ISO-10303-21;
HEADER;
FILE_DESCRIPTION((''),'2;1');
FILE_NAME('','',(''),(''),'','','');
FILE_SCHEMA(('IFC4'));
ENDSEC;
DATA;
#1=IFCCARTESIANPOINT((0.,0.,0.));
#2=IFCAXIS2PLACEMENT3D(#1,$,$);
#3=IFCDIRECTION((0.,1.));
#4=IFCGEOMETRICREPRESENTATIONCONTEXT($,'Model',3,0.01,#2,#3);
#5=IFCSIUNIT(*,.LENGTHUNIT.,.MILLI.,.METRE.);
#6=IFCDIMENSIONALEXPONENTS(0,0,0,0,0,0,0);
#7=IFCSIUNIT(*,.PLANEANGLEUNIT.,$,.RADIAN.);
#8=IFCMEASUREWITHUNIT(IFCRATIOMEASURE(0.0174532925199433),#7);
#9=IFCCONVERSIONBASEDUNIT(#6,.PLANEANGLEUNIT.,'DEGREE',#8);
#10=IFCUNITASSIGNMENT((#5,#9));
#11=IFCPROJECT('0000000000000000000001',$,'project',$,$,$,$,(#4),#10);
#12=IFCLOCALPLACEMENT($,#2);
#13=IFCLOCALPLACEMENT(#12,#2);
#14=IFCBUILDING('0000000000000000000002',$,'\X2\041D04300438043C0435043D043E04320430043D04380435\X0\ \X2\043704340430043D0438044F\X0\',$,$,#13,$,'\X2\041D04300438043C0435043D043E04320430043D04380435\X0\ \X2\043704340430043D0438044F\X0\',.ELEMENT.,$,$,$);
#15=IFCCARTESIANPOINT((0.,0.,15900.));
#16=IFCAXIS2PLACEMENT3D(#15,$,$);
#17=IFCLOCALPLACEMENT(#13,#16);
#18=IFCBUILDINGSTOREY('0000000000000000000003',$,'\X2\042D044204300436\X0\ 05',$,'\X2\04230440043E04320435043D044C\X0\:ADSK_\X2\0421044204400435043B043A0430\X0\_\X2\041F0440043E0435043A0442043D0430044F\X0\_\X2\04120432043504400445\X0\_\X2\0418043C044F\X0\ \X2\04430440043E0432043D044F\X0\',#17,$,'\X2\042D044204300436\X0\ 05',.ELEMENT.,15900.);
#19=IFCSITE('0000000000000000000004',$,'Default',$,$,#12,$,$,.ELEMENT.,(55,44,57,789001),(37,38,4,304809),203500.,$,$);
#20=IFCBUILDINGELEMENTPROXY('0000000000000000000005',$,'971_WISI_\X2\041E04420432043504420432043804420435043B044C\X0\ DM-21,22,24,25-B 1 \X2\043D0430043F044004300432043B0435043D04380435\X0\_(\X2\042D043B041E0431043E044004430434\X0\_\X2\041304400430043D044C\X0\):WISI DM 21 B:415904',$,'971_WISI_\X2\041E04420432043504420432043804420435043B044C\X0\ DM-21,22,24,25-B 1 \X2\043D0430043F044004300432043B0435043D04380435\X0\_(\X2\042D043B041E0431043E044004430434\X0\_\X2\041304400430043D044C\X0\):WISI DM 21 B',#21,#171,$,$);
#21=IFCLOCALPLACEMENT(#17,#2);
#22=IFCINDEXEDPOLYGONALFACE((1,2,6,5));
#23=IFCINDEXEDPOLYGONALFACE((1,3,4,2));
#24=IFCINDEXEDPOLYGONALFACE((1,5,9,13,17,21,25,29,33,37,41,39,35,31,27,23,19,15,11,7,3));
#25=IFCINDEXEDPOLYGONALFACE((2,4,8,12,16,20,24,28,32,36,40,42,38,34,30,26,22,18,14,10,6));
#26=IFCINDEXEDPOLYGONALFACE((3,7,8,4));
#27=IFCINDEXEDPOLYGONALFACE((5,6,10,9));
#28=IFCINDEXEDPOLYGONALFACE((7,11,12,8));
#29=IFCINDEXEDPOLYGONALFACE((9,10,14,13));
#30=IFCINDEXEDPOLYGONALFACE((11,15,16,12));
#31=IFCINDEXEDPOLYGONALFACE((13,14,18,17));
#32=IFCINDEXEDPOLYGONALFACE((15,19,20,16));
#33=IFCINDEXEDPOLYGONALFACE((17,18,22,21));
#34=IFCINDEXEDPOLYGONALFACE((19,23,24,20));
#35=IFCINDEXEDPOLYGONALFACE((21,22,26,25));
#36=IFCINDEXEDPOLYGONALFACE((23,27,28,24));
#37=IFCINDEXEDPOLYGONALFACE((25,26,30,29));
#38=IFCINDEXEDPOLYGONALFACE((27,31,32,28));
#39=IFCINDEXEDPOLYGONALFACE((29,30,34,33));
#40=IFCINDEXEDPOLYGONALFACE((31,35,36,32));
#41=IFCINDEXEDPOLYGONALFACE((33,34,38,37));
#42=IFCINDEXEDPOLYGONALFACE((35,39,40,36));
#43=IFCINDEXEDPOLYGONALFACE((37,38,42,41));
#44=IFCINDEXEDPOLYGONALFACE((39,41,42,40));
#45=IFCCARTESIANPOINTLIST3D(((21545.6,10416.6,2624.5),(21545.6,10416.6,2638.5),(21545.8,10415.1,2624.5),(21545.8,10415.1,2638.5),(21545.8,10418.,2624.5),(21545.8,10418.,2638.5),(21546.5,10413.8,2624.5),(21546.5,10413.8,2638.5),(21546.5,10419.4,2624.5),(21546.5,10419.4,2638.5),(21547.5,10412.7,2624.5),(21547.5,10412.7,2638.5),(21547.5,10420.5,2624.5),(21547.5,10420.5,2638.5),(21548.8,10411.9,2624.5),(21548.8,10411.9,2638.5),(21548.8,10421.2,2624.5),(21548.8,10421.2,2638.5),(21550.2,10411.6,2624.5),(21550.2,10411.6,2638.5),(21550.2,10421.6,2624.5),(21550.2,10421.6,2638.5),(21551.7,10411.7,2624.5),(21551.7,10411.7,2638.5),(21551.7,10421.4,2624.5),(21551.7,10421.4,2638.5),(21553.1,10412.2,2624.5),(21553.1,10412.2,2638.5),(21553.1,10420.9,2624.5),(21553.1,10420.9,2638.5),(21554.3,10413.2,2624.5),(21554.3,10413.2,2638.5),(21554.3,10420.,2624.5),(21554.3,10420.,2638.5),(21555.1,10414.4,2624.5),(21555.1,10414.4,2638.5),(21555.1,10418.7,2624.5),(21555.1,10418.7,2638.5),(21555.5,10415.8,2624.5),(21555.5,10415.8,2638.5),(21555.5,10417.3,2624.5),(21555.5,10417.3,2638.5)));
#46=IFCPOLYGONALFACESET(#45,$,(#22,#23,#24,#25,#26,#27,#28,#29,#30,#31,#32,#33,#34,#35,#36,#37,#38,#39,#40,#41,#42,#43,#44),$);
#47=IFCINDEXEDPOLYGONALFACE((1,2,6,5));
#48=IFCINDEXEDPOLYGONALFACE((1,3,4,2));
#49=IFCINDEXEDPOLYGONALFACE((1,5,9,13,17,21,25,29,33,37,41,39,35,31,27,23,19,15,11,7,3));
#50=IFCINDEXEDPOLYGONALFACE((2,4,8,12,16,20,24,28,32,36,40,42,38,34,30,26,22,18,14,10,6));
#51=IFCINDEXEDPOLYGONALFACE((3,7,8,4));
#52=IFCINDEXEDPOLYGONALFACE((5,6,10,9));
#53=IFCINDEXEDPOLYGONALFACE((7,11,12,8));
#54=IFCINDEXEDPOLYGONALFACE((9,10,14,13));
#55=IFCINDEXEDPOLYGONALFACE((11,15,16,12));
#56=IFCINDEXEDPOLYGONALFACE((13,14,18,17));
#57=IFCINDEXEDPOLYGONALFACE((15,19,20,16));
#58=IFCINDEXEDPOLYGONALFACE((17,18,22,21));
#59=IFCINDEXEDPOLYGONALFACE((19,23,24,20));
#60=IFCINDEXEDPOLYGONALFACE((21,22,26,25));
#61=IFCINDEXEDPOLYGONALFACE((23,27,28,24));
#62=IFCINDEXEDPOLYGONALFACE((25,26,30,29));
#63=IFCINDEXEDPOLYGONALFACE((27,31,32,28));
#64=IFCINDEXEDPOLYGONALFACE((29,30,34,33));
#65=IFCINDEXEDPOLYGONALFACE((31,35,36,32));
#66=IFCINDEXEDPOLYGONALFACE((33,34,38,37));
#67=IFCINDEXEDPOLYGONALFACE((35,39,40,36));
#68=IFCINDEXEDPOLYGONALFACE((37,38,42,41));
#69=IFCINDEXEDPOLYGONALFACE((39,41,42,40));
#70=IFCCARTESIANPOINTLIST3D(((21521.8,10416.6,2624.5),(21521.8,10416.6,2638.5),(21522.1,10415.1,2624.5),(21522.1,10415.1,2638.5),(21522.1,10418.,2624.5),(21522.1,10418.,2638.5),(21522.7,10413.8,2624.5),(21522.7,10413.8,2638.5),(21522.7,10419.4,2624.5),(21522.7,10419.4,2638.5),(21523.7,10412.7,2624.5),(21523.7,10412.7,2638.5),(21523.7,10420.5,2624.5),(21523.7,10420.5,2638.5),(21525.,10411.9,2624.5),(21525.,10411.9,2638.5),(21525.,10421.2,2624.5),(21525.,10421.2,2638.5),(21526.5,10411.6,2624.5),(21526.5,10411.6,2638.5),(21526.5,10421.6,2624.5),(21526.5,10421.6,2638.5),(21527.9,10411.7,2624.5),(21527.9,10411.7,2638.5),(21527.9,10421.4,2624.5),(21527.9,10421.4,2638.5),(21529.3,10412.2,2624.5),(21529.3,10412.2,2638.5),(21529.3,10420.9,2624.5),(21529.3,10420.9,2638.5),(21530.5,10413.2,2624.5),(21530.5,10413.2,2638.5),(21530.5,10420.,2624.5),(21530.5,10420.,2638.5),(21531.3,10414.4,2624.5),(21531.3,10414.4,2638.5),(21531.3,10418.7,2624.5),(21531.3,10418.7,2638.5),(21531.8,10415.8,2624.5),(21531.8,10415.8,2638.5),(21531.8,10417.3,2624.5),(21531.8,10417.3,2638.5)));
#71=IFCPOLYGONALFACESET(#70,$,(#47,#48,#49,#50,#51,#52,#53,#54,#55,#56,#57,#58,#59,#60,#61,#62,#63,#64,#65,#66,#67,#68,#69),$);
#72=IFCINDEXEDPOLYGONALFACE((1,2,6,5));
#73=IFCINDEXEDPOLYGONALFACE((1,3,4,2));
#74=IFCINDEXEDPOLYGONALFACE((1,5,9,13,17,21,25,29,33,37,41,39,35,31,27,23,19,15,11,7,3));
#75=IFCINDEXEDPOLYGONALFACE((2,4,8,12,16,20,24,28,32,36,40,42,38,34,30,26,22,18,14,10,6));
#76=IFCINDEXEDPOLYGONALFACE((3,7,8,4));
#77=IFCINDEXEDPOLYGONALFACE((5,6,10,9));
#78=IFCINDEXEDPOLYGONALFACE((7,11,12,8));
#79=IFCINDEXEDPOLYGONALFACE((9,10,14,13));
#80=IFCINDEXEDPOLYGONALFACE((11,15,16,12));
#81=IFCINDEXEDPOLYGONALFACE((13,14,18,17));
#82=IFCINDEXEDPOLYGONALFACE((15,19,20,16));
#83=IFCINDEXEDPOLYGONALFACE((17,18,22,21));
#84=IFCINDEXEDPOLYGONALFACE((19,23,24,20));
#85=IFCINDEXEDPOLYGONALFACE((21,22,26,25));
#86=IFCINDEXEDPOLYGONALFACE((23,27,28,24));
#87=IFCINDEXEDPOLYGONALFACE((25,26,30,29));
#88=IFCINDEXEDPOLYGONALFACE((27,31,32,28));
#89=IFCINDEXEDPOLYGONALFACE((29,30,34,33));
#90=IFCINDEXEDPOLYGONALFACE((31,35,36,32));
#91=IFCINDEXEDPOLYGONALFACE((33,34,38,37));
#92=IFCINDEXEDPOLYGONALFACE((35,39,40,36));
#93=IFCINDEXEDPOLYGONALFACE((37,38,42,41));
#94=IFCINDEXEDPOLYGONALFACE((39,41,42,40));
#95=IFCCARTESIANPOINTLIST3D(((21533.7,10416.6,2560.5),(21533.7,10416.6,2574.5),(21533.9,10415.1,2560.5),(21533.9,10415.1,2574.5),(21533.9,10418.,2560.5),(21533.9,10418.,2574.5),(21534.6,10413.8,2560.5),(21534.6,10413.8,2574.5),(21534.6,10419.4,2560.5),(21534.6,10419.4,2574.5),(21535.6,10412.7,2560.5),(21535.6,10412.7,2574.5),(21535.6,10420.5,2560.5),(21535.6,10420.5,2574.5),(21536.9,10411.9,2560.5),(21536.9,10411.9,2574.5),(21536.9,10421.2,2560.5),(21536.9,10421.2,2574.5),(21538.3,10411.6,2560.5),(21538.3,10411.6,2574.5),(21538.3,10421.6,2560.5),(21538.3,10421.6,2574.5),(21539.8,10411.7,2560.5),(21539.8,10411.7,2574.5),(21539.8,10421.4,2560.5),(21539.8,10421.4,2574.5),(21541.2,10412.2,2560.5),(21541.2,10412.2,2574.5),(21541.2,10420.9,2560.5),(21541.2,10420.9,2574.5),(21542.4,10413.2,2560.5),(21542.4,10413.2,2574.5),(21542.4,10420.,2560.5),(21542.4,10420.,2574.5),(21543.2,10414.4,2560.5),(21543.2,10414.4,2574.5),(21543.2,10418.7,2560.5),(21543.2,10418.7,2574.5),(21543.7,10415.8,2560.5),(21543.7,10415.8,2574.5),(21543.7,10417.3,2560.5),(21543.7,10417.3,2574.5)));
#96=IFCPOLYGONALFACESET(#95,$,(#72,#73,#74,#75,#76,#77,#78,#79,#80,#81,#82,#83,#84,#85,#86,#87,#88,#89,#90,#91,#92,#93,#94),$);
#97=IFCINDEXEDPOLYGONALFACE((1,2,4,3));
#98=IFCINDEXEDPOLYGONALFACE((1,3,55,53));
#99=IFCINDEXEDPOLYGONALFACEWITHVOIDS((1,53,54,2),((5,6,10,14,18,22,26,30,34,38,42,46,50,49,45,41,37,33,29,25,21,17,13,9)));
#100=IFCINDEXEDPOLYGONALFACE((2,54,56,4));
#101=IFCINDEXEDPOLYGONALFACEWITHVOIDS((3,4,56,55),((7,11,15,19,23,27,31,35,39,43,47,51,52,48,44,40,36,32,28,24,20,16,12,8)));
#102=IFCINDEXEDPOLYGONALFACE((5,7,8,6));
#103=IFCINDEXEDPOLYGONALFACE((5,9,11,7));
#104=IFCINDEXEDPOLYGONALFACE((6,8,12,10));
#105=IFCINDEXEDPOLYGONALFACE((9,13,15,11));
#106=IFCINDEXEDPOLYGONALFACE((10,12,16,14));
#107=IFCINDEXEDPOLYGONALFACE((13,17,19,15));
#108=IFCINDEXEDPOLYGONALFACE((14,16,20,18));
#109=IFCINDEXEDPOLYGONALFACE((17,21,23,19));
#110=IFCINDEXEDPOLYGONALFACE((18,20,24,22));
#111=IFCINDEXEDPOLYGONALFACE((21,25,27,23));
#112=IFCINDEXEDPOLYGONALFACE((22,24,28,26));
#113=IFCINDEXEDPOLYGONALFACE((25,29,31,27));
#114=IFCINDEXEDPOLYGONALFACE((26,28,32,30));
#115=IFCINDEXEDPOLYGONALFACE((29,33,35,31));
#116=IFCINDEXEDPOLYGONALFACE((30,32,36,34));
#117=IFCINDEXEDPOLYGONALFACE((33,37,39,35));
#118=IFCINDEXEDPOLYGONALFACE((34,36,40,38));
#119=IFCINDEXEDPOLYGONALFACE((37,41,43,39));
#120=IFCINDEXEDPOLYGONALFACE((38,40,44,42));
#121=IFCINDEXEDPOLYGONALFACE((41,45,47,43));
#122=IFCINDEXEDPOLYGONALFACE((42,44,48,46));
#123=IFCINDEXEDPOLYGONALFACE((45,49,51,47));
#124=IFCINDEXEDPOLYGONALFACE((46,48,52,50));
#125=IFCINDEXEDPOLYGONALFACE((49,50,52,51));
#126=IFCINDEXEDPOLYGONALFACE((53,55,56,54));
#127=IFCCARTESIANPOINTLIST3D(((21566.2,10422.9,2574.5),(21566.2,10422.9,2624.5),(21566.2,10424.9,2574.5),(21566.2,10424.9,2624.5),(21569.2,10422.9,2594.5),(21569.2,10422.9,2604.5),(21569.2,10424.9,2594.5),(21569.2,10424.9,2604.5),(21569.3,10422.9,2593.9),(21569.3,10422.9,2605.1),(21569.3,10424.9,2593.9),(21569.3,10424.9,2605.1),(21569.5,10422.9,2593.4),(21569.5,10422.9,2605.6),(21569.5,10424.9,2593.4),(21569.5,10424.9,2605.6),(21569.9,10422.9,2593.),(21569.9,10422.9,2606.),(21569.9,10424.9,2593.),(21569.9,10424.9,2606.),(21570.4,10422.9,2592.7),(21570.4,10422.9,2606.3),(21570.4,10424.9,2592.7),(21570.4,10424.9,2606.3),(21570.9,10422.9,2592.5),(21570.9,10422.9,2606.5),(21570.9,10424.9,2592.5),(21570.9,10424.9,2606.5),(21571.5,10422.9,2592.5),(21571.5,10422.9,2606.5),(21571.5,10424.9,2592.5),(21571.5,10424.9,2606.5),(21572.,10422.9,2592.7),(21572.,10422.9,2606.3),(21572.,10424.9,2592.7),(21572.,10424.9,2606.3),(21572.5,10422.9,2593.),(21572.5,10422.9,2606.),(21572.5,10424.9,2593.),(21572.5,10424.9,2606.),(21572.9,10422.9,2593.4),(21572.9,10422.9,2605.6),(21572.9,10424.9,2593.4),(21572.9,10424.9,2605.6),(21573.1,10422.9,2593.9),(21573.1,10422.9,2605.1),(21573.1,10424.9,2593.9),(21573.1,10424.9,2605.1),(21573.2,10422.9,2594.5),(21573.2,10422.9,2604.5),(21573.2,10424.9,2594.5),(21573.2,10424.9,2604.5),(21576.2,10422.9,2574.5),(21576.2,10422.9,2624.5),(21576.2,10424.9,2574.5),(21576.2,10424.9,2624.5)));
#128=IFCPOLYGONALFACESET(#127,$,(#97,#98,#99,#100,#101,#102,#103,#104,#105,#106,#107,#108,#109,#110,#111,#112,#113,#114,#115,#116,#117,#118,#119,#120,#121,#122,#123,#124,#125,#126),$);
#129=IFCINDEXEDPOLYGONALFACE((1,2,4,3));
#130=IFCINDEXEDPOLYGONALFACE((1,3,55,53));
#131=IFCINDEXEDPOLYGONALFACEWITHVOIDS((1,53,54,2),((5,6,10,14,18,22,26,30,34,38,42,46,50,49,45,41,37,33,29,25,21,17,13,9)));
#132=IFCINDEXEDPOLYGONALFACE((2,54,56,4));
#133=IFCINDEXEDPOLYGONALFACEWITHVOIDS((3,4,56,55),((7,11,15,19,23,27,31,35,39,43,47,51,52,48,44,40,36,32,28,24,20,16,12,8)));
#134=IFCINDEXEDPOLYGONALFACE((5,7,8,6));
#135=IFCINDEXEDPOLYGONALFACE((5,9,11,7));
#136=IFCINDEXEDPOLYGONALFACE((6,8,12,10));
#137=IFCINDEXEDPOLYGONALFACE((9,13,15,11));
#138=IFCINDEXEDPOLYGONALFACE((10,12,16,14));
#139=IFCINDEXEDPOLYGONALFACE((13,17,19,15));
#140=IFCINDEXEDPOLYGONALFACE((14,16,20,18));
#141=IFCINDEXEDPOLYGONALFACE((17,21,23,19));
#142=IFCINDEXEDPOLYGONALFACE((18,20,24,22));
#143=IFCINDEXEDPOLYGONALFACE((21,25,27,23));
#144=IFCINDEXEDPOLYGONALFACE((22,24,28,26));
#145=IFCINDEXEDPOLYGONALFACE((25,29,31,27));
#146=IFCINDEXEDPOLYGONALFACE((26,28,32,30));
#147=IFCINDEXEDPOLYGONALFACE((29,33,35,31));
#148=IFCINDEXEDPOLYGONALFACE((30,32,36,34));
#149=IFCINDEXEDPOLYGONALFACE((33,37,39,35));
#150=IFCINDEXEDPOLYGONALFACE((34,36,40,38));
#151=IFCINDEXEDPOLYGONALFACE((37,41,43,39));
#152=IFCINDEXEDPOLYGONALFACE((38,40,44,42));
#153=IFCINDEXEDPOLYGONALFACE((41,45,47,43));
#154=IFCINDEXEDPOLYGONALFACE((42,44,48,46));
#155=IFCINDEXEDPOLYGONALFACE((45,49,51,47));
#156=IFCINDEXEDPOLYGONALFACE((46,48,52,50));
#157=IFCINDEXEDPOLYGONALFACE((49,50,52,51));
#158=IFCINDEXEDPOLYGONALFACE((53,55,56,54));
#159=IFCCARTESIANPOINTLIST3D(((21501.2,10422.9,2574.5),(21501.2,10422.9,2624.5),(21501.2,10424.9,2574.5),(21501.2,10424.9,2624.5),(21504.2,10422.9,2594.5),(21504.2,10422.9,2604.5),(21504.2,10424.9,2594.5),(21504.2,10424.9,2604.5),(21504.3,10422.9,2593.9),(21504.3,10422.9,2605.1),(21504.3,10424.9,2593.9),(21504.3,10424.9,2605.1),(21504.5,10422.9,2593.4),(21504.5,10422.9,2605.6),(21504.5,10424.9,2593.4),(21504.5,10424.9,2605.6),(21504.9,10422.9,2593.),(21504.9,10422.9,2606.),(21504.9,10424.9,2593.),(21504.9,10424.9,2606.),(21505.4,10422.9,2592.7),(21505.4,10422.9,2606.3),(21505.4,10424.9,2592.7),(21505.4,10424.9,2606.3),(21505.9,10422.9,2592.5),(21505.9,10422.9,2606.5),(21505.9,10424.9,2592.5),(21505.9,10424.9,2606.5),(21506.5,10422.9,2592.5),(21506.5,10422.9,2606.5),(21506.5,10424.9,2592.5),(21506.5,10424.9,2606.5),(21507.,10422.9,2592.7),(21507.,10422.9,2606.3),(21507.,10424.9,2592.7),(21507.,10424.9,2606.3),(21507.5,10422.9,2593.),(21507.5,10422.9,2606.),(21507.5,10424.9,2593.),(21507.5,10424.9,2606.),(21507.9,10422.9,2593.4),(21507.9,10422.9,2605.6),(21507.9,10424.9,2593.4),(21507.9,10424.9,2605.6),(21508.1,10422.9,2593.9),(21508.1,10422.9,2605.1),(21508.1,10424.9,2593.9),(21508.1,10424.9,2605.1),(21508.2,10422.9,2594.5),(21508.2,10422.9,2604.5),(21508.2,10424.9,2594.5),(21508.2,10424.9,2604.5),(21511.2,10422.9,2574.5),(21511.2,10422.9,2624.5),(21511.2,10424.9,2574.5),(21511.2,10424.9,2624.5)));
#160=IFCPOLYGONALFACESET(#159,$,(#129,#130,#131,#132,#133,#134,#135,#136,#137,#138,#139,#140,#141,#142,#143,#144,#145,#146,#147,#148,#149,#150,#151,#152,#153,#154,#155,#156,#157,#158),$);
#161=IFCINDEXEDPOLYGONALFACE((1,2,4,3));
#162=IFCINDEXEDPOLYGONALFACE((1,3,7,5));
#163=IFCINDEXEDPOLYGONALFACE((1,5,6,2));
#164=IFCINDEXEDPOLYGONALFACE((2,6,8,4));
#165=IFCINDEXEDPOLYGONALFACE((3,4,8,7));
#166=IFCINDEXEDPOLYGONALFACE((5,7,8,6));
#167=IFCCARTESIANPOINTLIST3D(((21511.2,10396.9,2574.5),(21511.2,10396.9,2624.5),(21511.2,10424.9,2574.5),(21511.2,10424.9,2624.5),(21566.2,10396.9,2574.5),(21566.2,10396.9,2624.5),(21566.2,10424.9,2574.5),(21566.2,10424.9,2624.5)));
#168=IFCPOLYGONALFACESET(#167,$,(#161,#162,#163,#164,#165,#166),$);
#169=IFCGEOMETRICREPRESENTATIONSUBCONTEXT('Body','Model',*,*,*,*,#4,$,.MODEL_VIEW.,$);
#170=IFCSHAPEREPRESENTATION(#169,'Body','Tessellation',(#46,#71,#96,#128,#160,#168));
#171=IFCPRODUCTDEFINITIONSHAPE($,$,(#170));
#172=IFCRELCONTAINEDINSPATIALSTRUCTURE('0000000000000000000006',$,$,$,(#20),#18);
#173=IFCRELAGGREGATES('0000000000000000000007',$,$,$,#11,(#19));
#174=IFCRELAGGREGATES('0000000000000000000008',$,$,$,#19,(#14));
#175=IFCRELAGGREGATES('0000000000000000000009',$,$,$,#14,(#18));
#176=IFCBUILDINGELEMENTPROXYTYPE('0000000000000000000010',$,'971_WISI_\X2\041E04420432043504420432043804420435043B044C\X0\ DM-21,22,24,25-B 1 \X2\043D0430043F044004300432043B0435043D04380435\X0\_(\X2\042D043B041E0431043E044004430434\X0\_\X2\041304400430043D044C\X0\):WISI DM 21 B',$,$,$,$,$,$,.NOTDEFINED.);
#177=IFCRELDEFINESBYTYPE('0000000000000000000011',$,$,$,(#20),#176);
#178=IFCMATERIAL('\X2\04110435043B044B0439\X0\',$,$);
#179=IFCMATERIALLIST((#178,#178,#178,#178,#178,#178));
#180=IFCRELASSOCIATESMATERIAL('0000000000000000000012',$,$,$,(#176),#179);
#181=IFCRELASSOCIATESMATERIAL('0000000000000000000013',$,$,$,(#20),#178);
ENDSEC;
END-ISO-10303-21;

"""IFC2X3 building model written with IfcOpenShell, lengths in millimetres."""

from ifc_helpers import new_model, entity, si_unit, converted_unit, direction, frame, frame_2d, origin, place, context, subcontext, project, spatial, polyline, circle_curve, parameter, trimmed, segment, composite_curve, rectangle, circle, outline, extrude, source, transform, mapped, material, material_list, type_object, type_shapes, element, save


model = new_model("IFC2X3")

# Units and contexts
model_context = context("Model", 3, precision=0.01, world=origin(), true_north=direction((0.0, 1.0)))
body_context = subcontext(model_context, "Body", "Model", "MODEL_VIEW")
ifc_project = project(units=[si_unit("LENGTHUNIT", "METRE", prefix="MILLI"), converted_unit("PLANEANGLEUNIT", "DEGREE", entity("IfcRatioMeasure", 0.0174532925199433), si_unit("PLANEANGLEUNIT", "RADIAN"), dimensions=[0, 0, 0, 0, 0, 0, 0])], contexts=[model_context])

# Site, building, storey
site_placement = place(None, frame((0.0, 0.0, 0.0)))
site = spatial("IfcSite", under=ifc_project, at=site_placement, Name="Default", CompositionType="ELEMENT", RefLatitude=(55, 44, 57, 789001), RefLongitude=(37, 38, 4, 304809), RefElevation=203500.0)
building_placement = place(site_placement, origin())
building = spatial("IfcBuilding", under=site, at=building_placement, Name="Наименование здания", LongName="Наименование здания", CompositionType="ELEMENT")
storey_placement = place(building_placement, frame((0.0, 0.0, 15900.0)))
storey = spatial("IfcBuildingStorey", under=building, at=storey_placement, Name="Этаж 05", ObjectType="Уровень:ADSK_Стрелка_Проектная_Вверх_Имя уровня", LongName="Этаж 05", CompositionType="ELEMENT", Elevation=15900.0)

# Building element proxy
ifc_material = material(Name="Белый")
ifc_material_list = material_list([ifc_material, ifc_material, ifc_material, ifc_material, ifc_material, ifc_material])
building_element_proxy_type = type_object("IfcBuildingElementProxyType", Name="971_WISI_Ответвитель DM-21,22,24,25-B 1 направление_(ЭлОборуд_Грань):WISI DM 21 B", PredefinedType="NOTDEFINED", material=ifc_material_list)
shared_shape = source(origin(), body_context, "Body", "SweptSolid", [
    extrude(circle(Radius=5.0, at=frame_2d((0.0, 0.0), x_axis=(1.0, 0.0))), frame((11.9, 25.0, 8.4), z_axis=(0.0, 1.0, 0.0), x_axis=(-1.0, 0.0, 0.0)), (0.0, 0.0, 1.0), 14.0),
    extrude(circle(Radius=5.0, at=frame_2d((0.0, 0.0), x_axis=(1.0, 0.0))), frame((-11.8, 25.0, 8.4), z_axis=(0.0, 1.0, 0.0), x_axis=(-1.0, 0.0, 0.0)), (0.0, 0.0, 1.0), 14.0),
    extrude(circle(Radius=5.0, at=frame_2d((0.0, 0.0), x_axis=(1.0, 0.0))), frame((0.0, -39.0, 8.4), z_axis=(0.0, 1.0, 0.0), x_axis=(-1.0, 0.0, 0.0)), (0.0, 0.0, 1.0), 14.0),
    extrude(outline(polyline([(-5.0, -25.0), (5.0, -25.0), (5.0, 25.0), (-5.0, 25.0), (-5.0, -25.0)]), holes=[composite_curve([segment(polyline([(2.0, 5.0), (2.0, -5.0)]), True, "CONTINUOUS"), segment(trimmed(circle_curve(frame_2d((0.0, -5.0), x_axis=(-1.0, 0.0)), 2.0), [parameter(0.0)], [parameter(180.0)], True, "PARAMETER"), False, "CONTINUOUS"), segment(polyline([(-2.0, -5.0), (-2.0, 5.0)]), True, "CONTINUOUS"), segment(trimmed(circle_curve(frame_2d((0.0, 5.0), x_axis=(-1.0, 0.0)), 2.0), [parameter(180.0)], [parameter(0.0)], True, "PARAMETER"), False, "CONTINUOUS")], self_intersect=False)]), frame((32.5, 0.0, 0.0), z_axis=(0.0, 0.0, 1.0), x_axis=(-1.0, 0.0, 0.0)), (0.0, 0.0, 1.0), 2.0),
    extrude(outline(polyline([(-5.0, -25.0), (5.0, -25.0), (5.0, 25.0), (-5.0, 25.0), (-5.0, -25.0)]), holes=[composite_curve([segment(polyline([(-2.0, -5.0), (-2.0, 5.0)]), True, "CONTINUOUS"), segment(trimmed(circle_curve(frame_2d((0.0, 5.0), x_axis=(-1.0, 0.0)), 2.0), [parameter(180.0)], [parameter(0.0)], True, "PARAMETER"), False, "CONTINUOUS"), segment(polyline([(2.0, 5.0), (2.0, -5.0)]), True, "CONTINUOUS"), segment(trimmed(circle_curve(frame_2d((0.0, -5.0), x_axis=(-1.0, 0.0)), 2.0), [parameter(0.0)], [parameter(180.0)], True, "PARAMETER"), False, "CONTINUOUS")], self_intersect=False)]), frame((-32.5, 0.0, 0.0), z_axis=(0.0, 0.0, 1.0), x_axis=(-1.0, 0.0, 0.0)), (0.0, 0.0, 1.0), 2.0),
    extrude(rectangle(XDim=55.0, YDim=50.0, at=frame_2d((0.0, 0.0), x_axis=(1.0, 0.0))), frame((0.0, 0.0, 0.0), z_axis=(0.0, 0.0, 1.0), x_axis=(-1.0, 0.0, 0.0)), (0.0, 0.0, 1.0), 28.0),
])
type_shapes(building_element_proxy_type, [shared_shape])
for number, where, z_axis, x_axis, name in (
    (1, (21538.7, 10424.9, 2599.5), (0.0, -1.0, 0.0), (1.0, 0.0, 0.0), "971_WISI_Ответвитель DM-21,22,24,25-B 1 направление_(ЭлОборуд_Грань):WISI DM 21 B:415904"),
):
    element("IfcBuildingElementProxy", number, at=place(storey_placement, frame(where, z_axis=z_axis, x_axis=x_axis)), inside=storey, type_object=building_element_proxy_type, material=ifc_material, Name=name, ObjectType="971_WISI_Ответвитель DM-21,22,24,25-B 1 направление_(ЭлОборуд_Грань):WISI DM 21 B", context=body_context, shape_type="MappedRepresentation", body=[
        mapped(shared_shape, transform((0.0, 0.0, 0.0), scale=1.0)),
    ])

save(model, "model.ifc")
